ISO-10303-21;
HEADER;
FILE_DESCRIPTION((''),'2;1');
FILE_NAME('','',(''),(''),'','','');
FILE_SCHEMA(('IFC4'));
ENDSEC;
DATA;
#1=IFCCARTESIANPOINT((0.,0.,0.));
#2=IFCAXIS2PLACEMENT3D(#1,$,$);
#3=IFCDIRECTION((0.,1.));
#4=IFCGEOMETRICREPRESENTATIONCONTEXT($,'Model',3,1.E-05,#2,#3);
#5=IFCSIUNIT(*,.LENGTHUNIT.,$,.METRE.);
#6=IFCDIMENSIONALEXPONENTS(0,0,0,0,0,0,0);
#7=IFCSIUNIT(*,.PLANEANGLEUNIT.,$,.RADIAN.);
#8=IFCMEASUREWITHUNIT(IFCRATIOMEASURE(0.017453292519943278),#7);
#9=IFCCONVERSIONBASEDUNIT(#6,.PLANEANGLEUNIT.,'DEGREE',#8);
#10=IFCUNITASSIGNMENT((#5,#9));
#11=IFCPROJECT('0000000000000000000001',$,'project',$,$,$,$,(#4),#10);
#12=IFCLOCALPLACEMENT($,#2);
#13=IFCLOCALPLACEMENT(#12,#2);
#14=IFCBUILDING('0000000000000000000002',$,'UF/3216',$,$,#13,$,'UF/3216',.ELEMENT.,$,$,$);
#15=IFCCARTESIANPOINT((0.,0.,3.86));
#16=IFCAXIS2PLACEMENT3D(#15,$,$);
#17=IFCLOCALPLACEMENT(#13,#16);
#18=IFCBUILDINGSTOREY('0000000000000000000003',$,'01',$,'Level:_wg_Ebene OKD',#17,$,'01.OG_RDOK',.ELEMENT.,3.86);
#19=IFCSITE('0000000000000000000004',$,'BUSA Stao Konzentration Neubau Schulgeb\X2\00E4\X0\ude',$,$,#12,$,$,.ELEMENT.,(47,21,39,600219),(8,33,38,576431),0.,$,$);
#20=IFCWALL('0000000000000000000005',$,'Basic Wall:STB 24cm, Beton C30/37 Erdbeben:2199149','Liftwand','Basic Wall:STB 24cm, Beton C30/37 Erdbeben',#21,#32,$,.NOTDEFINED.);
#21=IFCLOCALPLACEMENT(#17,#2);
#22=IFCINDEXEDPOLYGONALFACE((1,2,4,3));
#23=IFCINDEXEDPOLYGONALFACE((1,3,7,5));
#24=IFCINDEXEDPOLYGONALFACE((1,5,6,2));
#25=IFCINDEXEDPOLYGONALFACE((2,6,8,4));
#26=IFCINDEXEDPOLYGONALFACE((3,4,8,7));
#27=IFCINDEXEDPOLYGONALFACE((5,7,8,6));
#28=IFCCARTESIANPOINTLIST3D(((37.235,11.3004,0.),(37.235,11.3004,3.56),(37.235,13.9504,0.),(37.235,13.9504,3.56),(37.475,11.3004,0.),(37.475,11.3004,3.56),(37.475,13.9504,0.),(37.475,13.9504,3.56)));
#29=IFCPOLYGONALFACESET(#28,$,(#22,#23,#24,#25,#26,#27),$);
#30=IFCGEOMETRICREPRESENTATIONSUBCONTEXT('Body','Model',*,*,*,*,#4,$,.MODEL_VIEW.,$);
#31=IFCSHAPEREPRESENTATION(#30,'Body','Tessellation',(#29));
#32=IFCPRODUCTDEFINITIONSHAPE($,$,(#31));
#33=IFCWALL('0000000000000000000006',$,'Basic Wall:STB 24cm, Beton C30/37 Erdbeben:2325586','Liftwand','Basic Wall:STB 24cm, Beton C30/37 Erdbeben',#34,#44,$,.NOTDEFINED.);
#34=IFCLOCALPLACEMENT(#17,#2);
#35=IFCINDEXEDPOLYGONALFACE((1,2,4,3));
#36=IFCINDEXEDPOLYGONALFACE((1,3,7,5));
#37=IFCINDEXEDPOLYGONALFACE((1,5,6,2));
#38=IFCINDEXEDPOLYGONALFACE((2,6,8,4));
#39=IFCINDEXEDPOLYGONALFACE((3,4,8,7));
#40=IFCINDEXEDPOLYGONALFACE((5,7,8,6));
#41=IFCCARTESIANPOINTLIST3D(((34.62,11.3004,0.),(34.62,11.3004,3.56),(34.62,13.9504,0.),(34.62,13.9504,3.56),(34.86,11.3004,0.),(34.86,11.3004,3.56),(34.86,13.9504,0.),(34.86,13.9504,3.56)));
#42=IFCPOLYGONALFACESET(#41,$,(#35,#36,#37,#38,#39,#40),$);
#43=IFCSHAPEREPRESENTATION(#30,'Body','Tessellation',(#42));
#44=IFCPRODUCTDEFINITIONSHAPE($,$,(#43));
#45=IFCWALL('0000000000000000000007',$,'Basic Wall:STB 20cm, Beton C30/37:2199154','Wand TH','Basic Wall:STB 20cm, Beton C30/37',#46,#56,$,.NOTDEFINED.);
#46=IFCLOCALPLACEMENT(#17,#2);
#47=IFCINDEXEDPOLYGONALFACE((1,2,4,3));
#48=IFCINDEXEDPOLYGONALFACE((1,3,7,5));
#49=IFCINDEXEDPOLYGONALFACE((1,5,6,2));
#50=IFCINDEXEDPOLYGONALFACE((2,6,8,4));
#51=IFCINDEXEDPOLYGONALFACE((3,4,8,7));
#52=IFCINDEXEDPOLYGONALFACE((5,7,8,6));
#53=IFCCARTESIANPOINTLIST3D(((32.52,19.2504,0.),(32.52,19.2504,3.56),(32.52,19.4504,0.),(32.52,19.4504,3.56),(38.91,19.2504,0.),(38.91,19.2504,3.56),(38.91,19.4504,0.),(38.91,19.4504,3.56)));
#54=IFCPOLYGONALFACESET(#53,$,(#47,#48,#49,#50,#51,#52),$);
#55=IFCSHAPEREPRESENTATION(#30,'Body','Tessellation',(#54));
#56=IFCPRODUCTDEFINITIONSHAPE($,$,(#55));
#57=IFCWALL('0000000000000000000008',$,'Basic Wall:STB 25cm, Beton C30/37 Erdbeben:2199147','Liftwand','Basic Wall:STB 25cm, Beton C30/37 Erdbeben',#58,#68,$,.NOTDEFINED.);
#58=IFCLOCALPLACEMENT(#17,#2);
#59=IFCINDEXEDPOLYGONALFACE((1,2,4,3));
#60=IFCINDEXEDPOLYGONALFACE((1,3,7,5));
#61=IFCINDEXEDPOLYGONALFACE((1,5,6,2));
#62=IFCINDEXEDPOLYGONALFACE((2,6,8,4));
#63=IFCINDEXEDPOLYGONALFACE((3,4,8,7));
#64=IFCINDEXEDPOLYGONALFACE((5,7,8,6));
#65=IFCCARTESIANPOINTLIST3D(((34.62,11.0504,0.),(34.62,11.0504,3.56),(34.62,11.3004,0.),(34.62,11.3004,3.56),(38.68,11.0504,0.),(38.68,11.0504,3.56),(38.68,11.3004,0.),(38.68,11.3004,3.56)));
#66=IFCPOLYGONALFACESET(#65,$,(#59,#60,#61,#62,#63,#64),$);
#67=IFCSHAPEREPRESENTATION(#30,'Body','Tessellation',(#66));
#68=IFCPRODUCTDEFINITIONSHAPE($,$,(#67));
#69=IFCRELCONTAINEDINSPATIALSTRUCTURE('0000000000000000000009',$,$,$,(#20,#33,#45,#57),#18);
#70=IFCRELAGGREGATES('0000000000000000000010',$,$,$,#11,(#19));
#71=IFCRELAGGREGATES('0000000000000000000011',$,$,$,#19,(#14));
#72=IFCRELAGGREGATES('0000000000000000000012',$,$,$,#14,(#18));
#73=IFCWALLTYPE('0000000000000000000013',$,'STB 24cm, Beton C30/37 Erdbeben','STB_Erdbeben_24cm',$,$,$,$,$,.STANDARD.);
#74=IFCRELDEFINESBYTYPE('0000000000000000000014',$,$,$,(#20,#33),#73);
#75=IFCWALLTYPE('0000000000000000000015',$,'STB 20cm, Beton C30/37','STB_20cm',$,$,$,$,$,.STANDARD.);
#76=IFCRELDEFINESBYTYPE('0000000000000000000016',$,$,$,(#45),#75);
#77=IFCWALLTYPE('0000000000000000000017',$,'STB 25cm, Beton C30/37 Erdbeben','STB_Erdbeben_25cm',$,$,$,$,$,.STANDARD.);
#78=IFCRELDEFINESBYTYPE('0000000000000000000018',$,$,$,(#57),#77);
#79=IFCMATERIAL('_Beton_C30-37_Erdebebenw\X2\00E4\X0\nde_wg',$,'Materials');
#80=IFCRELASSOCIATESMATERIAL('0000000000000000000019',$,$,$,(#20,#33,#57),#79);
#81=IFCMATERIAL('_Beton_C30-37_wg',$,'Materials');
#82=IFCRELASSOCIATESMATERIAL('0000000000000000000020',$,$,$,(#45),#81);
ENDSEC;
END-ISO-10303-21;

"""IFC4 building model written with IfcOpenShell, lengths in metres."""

from ifc_helpers import new_model, entity, si_unit, converted_unit, direction, frame, origin, place, context, subcontext, project, spatial, indexed_curve, outline, extrude, material, type_object, element, save


model = new_model("IFC4")

# Units and contexts
model_context = context("Model", 3, precision=1e-05, world=origin(), true_north=direction((0.0, 1.0)))
body_context = subcontext(model_context, "Body", "Model", "MODEL_VIEW")
ifc_project = project(units=[si_unit("LENGTHUNIT", "METRE"), converted_unit("PLANEANGLEUNIT", "DEGREE", entity("IfcRatioMeasure", 0.017453292519943278), si_unit("PLANEANGLEUNIT", "RADIAN"), dimensions=[0, 0, 0, 0, 0, 0, 0])], contexts=[model_context])

# Site, building, storey
site_placement = place(None, origin())
site = spatial("IfcSite", under=ifc_project, at=site_placement, Name="BUSA Stao Konzentration Neubau Schulgebäude", CompositionType="ELEMENT", RefLatitude=(47, 21, 39, 600219), RefLongitude=(8, 33, 38, 576431), RefElevation=0.0)
building_placement = place(site_placement, origin())
building = spatial("IfcBuilding", under=site, at=building_placement, Name="UF/3216", LongName="UF/3216", CompositionType="ELEMENT")
storey_placement = place(building_placement, frame((0.0, 0.0, 3.86)))
storey = spatial("IfcBuildingStorey", under=building, at=storey_placement, Name="01", ObjectType="Level:_wg_Ebene OKD", LongName="01.OG_RDOK", CompositionType="ELEMENT", Elevation=3.86)

# Walls
ifc_material_1 = material(Name="_Beton_C30-37_Erdebebenwände_wg", Category="Materials")
wall_type_1 = type_object("IfcWallType", Name="STB 24cm, Beton C30/37 Erdbeben", Description="STB_Erdbeben_24cm", PredefinedType="STANDARD")
for number, where, z_axis, x_axis, name in (
    (1, (37.355, 13.9504, 0.0), (0.0, 0.0, 1.0), (0.0, -1.0, 0.0), "Basic Wall:STB 24cm, Beton C30/37 Erdbeben:2199149"),
    (2, (34.74, 11.3004, 0.0), (0.0, 0.0, 1.0), (0.0, 1.0, 0.0), "Basic Wall:STB 24cm, Beton C30/37 Erdbeben:2325586"),
):
    element("IfcWall", number, at=place(storey_placement, frame(where, z_axis=z_axis, x_axis=x_axis)), inside=storey, type_object=wall_type_1, material=ifc_material_1, Name=name, Description="Liftwand", ObjectType="Basic Wall:STB 24cm, Beton C30/37 Erdbeben", PredefinedType="NOTDEFINED", context=body_context, shape_type="SweptSolid", body=[
        extrude(outline(indexed_curve([(2.65, 0.12), (0.0, 0.12), (0.0, -0.12), (2.65, -0.12), (2.65, 0.12)], self_intersect=False)), origin(), (0.0, 0.0, 1.0), 3.56),
    ])
ifc_material_2 = material(Name="_Beton_C30-37_wg", Category="Materials")
wall_type_2 = type_object("IfcWallType", Name="STB 20cm, Beton C30/37", Description="STB_20cm", PredefinedType="STANDARD")
wall_1_placement = place(storey_placement, frame((32.52, 19.3504, 0.0)))
element("IfcWall", 3, at=wall_1_placement, inside=storey, type_object=wall_type_2, material=ifc_material_2, Name="Basic Wall:STB 20cm, Beton C30/37:2199154", Description="Wand TH", ObjectType="Basic Wall:STB 20cm, Beton C30/37", PredefinedType="NOTDEFINED", context=body_context, shape_type="SweptSolid", body=[
    extrude(outline(indexed_curve([(6.39, 0.1), (0.0, 0.1), (0.0, -0.1), (6.39, -0.1), (6.39, 0.1)], self_intersect=False)), origin(), (0.0, 0.0, 1.0), 3.56),
])
wall_type_3 = type_object("IfcWallType", Name="STB 25cm, Beton C30/37 Erdbeben", Description="STB_Erdbeben_25cm", PredefinedType="STANDARD")
wall_2_placement = place(storey_placement, frame((38.68, 11.1754, 0.0), z_axis=(0.0, 0.0, 1.0), x_axis=(-1.0, 0.0, 0.0)))
element("IfcWall", 4, at=wall_2_placement, inside=storey, type_object=wall_type_3, material=ifc_material_1, Name="Basic Wall:STB 25cm, Beton C30/37 Erdbeben:2199147", Description="Liftwand", ObjectType="Basic Wall:STB 25cm, Beton C30/37 Erdbeben", PredefinedType="NOTDEFINED", context=body_context, shape_type="SweptSolid", body=[
    extrude(outline(indexed_curve([(4.06, 0.125), (0.0, 0.125), (0.0, -0.125), (4.06, -0.125), (4.06, 0.125)], self_intersect=False)), origin(), (0.0, 0.0, 1.0), 3.56),
])

save(model, "model.ifc")
